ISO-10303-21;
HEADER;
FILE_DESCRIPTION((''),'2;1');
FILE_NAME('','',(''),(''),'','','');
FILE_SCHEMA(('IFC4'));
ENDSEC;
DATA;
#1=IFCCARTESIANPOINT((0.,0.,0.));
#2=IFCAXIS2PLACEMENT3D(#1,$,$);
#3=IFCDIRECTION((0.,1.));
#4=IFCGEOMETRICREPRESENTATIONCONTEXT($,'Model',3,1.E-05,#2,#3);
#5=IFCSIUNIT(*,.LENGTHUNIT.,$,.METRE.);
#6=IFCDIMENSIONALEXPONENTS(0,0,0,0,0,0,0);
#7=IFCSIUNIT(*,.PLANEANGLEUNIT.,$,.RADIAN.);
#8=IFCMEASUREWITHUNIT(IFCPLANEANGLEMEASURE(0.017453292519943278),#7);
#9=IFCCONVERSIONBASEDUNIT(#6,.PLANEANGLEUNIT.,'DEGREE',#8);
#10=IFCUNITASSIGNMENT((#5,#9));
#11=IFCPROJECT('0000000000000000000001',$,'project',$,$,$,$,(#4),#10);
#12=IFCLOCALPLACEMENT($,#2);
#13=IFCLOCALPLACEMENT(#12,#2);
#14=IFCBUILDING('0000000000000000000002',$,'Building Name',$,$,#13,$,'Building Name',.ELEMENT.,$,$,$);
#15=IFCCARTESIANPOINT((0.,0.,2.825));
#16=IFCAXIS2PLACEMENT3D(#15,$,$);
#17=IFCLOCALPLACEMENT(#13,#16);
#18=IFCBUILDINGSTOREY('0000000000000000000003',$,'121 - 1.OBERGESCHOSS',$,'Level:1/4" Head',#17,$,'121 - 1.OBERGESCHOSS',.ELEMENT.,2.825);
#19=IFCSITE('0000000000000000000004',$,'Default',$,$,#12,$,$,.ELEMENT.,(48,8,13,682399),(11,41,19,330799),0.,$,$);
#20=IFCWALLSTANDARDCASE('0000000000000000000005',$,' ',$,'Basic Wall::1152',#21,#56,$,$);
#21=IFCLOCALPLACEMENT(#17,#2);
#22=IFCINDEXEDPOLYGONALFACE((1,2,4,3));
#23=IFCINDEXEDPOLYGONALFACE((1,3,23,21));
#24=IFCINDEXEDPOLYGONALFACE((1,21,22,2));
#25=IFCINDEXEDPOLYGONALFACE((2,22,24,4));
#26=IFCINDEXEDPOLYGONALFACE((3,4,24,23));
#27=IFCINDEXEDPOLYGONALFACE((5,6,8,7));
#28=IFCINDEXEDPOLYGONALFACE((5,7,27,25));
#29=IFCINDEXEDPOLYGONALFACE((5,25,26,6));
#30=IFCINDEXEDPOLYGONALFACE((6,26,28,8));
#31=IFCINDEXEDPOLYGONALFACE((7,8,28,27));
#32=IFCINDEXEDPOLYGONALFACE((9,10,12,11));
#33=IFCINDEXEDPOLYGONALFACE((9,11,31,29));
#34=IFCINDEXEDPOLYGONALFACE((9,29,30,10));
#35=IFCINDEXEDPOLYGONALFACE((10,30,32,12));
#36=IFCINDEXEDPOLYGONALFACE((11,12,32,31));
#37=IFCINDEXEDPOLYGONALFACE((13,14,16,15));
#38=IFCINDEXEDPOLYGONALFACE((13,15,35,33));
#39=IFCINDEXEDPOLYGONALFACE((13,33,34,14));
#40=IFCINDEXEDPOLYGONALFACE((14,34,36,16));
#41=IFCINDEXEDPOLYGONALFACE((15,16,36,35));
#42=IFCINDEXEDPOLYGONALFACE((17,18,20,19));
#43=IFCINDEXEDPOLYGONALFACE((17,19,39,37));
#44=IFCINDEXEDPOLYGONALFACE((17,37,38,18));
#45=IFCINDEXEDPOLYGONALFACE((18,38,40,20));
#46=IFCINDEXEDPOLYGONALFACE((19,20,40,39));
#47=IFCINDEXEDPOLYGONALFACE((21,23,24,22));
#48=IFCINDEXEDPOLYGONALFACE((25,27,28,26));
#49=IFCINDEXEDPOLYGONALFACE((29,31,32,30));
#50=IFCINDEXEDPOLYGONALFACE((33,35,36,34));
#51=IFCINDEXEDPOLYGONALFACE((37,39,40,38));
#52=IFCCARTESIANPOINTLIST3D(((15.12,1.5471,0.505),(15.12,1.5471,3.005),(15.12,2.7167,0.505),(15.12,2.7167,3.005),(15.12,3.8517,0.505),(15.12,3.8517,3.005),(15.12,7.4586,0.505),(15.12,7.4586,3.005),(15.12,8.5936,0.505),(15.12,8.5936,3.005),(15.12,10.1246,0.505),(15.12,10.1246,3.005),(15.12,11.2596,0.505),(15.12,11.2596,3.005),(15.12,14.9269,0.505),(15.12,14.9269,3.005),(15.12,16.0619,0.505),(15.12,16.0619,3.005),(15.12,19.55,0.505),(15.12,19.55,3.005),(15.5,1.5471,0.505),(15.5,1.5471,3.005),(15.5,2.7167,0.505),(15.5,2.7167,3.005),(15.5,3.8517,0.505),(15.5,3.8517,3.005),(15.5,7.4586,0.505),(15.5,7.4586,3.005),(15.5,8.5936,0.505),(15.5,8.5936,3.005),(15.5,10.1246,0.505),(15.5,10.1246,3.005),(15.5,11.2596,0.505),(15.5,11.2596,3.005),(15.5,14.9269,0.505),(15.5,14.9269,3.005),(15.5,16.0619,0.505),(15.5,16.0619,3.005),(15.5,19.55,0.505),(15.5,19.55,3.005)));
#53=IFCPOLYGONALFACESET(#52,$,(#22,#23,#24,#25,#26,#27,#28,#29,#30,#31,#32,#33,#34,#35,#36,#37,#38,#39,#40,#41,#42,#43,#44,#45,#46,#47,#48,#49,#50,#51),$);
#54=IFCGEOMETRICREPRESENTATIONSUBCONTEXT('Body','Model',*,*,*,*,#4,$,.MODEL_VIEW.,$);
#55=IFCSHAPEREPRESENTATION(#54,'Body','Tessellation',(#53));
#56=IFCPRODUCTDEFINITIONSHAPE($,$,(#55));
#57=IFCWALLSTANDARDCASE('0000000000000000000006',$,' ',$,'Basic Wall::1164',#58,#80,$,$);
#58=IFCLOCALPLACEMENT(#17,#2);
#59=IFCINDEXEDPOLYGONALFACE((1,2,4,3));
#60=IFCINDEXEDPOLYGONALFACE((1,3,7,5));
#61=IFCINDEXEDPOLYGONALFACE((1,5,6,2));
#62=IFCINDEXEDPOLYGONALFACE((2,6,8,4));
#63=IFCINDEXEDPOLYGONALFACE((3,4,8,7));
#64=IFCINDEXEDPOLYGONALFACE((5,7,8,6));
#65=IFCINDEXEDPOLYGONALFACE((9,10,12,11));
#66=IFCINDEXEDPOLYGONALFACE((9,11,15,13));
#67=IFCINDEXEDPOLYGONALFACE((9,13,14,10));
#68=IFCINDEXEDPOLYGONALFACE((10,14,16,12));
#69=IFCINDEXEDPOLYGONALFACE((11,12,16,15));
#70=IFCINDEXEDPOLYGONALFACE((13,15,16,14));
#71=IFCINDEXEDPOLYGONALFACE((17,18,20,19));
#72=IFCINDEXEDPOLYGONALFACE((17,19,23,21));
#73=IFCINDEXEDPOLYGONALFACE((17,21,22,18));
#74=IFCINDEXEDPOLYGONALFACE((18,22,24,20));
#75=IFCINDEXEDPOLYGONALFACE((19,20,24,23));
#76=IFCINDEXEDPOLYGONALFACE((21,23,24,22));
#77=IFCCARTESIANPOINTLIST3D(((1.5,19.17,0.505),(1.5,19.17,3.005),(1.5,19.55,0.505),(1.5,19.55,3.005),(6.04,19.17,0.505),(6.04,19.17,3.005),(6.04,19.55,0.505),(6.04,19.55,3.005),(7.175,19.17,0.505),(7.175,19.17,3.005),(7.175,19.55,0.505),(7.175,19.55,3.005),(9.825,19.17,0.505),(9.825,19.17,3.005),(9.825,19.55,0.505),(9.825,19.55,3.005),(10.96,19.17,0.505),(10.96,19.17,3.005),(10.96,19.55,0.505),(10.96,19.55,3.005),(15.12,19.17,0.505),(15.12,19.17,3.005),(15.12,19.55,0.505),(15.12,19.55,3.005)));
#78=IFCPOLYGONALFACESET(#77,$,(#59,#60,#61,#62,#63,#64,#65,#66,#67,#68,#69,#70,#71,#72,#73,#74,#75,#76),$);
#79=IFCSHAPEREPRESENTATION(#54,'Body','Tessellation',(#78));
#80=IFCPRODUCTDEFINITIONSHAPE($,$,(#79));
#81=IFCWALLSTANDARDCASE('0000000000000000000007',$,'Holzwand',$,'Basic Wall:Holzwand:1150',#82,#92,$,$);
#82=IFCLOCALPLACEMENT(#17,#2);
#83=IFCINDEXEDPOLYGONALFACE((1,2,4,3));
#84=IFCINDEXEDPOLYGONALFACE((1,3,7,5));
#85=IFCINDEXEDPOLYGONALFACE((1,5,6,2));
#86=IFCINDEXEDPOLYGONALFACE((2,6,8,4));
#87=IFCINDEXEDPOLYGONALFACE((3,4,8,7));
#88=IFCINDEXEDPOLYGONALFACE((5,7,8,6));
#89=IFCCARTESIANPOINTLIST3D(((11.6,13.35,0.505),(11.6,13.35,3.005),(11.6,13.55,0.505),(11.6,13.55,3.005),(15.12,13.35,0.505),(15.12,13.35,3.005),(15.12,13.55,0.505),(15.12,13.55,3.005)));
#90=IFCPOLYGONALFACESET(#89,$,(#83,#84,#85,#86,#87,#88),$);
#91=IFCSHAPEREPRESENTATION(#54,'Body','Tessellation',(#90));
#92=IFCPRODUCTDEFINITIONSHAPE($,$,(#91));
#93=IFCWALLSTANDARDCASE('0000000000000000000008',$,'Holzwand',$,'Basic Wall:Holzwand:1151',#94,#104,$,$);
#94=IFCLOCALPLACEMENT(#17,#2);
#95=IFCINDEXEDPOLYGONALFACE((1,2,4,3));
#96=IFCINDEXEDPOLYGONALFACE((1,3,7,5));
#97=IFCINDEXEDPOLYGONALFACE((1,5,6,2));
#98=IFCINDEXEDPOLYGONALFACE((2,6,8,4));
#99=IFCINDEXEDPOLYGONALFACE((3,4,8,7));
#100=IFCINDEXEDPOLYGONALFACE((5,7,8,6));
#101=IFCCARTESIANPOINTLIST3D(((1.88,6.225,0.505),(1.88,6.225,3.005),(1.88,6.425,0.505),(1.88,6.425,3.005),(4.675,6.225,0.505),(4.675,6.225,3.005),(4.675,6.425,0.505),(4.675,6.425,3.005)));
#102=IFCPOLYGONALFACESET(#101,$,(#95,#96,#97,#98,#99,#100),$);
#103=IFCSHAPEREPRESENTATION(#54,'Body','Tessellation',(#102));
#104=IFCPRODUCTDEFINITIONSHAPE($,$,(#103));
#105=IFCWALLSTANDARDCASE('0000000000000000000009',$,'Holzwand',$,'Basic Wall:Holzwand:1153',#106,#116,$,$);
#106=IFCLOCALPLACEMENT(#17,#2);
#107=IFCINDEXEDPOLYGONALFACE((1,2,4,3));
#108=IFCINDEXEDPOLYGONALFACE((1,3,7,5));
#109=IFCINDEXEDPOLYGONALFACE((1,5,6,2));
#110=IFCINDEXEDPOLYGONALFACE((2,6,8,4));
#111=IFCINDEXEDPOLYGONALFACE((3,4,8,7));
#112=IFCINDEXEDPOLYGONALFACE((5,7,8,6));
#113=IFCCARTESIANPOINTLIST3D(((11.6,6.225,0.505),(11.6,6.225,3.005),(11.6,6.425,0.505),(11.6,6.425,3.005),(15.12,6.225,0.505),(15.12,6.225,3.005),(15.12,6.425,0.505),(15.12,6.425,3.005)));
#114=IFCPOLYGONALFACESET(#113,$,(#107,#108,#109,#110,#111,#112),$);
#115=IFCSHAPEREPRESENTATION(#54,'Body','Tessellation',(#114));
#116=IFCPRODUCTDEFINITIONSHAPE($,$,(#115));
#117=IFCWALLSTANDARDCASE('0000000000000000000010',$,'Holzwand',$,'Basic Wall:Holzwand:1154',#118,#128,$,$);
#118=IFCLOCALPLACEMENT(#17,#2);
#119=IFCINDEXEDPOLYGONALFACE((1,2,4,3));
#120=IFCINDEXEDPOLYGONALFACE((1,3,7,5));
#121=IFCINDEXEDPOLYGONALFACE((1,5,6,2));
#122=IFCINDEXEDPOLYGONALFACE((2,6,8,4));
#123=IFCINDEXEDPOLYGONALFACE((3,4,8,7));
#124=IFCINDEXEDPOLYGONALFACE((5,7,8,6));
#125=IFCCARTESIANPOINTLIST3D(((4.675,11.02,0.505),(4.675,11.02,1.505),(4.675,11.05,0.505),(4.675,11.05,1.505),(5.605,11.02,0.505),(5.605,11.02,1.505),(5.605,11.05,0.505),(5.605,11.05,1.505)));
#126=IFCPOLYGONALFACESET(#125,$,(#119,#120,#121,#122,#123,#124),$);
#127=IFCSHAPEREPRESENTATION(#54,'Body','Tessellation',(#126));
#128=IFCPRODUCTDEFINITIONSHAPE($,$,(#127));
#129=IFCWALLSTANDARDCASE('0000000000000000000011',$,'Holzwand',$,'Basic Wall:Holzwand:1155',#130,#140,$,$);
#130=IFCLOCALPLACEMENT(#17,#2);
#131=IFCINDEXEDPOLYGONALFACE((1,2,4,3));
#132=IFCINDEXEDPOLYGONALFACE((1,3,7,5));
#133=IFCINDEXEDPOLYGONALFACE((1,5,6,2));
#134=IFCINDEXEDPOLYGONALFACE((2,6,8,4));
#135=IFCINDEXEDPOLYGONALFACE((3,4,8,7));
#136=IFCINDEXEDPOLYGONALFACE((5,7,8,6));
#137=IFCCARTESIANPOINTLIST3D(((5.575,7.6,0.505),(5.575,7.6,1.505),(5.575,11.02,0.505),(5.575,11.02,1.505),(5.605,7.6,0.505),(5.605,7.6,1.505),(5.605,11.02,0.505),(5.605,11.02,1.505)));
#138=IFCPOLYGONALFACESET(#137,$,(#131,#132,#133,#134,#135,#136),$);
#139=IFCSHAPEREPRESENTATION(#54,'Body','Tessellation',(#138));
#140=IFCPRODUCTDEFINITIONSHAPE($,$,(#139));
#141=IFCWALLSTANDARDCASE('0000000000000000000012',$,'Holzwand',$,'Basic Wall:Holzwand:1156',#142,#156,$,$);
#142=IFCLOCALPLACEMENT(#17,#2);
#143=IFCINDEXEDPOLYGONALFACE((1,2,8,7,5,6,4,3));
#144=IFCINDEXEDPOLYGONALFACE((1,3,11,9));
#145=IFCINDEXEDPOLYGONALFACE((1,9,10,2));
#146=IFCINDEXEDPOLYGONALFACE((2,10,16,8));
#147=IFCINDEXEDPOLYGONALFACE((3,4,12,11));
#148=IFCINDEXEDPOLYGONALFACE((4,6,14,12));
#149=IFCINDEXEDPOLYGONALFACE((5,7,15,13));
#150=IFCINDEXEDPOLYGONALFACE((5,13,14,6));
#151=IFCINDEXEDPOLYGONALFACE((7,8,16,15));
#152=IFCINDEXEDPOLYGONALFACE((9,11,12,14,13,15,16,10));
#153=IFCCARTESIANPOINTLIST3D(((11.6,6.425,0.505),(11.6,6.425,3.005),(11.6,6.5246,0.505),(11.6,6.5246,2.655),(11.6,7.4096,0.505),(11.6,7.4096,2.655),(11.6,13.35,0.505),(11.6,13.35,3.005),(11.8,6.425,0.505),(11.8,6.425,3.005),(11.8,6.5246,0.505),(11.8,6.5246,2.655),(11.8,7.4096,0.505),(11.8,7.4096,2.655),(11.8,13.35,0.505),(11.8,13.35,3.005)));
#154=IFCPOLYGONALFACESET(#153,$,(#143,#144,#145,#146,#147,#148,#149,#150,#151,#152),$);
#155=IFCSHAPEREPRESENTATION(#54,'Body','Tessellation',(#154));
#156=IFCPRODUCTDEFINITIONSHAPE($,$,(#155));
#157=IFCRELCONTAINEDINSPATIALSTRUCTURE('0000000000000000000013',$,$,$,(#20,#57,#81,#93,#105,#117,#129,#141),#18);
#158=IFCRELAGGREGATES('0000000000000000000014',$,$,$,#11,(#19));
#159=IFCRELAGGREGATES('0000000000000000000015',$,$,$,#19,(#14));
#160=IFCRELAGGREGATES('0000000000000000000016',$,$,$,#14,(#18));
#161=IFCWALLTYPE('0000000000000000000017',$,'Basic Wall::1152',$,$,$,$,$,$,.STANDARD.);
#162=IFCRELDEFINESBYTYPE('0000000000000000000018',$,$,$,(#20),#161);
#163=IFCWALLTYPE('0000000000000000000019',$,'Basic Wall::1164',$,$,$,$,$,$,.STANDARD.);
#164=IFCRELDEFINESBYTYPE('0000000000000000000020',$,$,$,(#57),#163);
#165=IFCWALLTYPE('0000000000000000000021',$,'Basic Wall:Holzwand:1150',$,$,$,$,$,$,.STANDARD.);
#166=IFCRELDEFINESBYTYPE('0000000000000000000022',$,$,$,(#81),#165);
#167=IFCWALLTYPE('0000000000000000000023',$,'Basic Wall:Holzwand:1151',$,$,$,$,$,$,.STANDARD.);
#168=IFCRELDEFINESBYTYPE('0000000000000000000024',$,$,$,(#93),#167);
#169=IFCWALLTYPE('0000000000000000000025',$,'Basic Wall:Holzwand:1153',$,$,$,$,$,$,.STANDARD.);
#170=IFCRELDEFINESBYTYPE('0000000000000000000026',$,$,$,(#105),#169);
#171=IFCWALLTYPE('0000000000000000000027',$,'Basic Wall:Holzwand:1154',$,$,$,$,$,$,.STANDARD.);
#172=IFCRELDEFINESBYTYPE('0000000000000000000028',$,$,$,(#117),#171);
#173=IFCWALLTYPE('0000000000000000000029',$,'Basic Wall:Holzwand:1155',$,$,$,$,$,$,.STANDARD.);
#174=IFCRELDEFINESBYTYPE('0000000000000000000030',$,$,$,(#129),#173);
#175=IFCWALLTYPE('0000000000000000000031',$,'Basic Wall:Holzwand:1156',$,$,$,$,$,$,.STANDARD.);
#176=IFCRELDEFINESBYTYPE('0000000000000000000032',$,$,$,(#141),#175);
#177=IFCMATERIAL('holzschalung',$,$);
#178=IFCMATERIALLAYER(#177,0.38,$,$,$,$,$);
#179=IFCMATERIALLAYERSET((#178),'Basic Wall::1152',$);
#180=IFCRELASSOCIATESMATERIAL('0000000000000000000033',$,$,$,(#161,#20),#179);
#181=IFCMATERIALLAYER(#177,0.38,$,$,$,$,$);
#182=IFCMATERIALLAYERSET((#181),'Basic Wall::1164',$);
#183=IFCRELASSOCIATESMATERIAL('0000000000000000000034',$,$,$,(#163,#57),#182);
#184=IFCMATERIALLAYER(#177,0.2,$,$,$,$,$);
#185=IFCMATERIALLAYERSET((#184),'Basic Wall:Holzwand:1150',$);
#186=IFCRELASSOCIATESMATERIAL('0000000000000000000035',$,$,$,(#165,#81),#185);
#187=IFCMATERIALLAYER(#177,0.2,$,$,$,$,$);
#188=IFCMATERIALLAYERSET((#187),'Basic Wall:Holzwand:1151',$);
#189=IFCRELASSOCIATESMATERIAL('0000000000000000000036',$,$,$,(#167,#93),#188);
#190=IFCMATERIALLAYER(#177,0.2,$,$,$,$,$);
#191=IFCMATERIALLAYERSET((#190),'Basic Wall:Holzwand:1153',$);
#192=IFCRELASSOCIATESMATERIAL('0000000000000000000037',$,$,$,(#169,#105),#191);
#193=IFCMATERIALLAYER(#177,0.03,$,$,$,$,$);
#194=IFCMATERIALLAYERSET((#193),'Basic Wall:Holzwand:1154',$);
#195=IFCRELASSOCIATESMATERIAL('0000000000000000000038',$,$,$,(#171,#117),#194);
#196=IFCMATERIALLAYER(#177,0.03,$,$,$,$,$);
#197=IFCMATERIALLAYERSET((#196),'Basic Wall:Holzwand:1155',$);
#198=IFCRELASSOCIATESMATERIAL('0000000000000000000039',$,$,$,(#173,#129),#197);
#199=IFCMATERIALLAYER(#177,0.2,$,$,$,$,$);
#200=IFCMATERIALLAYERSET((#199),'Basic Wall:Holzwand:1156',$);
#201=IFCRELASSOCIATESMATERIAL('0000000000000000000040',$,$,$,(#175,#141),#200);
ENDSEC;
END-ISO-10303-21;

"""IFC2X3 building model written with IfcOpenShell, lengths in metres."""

from ifc_helpers import new_model, entity, si_unit, converted_unit, direction, frame, frame_2d, origin, place, context, subcontext, project, spatial, rectangle, extrude, material, layer, layer_set, layer_usage, type_object, element, save


model = new_model("IFC2X3")

# Units and contexts
model_context = context("Model", 3, precision=1e-05, world=origin(), true_north=direction((0.0, 1.0)))
body_context = subcontext(model_context, "Body", "Model", "MODEL_VIEW")
ifc_project = project(units=[si_unit("LENGTHUNIT", "METRE"), converted_unit("PLANEANGLEUNIT", "DEGREE", entity("IfcPlaneAngleMeasure", 0.017453292519943278), si_unit("PLANEANGLEUNIT", "RADIAN"), dimensions=[0, 0, 0, 0, 0, 0, 0])], contexts=[model_context])

# Site, building, storey
site_placement = place(None, origin())
site = spatial("IfcSite", under=ifc_project, at=site_placement, Name="Default", CompositionType="ELEMENT", RefLatitude=(48, 8, 13, 682399), RefLongitude=(11, 41, 19, 330799), RefElevation=0.0)
building_placement = place(site_placement, origin())
building = spatial("IfcBuilding", under=site, at=building_placement, Name="Building Name", LongName="Building Name", CompositionType="ELEMENT")
storey_placement = place(building_placement, frame((0.0, 0.0, 2.825)))
storey = spatial("IfcBuildingStorey", under=building, at=storey_placement, Name="121 - 1.OBERGESCHOSS", ObjectType="Level:1/4\" Head", LongName="121 - 1.OBERGESCHOSS", CompositionType="ELEMENT", Elevation=2.825)

# Walls, openings
ifc_material = material(Name="holzschalung")
ifc_layer_1 = layer(ifc_material, 0.38)
ifc_layer_set_1 = layer_set([ifc_layer_1], Name="Basic Wall::1152")
ifc_layer_usage_1 = layer_usage(ifc_layer_set_1, "AXIS2", "NEGATIVE", 0.19)
wall_type_1 = type_object("IfcWallType", Name="Basic Wall::1152", PredefinedType="STANDARD", material=ifc_layer_set_1)
wall_1_placement = place(storey_placement, frame((15.31, 19.55, 0.505), z_axis=(0.0, 0.0, 1.0), x_axis=(0.0, -1.0, 0.0)))
wall_1 = element("IfcWallStandardCase", 1, at=wall_1_placement, inside=storey, type_object=wall_type_1, material=ifc_layer_usage_1, Name=" ", ObjectType="Basic Wall::1152", context=body_context, shape_type="SweptSolid", body=[
    extrude(rectangle(XDim=18.0029, YDim=0.38, at=frame_2d((9.0014, 0.0), x_axis=(-1.0, 0.0))), origin(), (0.0, 0.0, 1.0), 2.5),
])
opening_1_placement = place(wall_1_placement, origin())
element("IfcOpeningElement", 2, at=opening_1_placement, cuts=wall_1, ObjectType="Opening", context=body_context, shape_type="SweptSolid", body=[
    extrude(rectangle(XDim=2.5, YDim=1.135, at=frame_2d((0.0, 0.0), x_axis=(1.0, 0.0))), frame((4.0556, -0.19, 1.25), z_axis=(0.0, 1.0, 0.0), x_axis=(0.0, 0.0, 1.0)), (0.0, 0.0, 1.0), 0.38),
])
opening_2_placement = place(wall_1_placement, origin())
element("IfcOpeningElement", 3, at=opening_2_placement, cuts=wall_1, ObjectType="Opening", context=body_context, shape_type="SweptSolid", body=[
    extrude(rectangle(XDim=2.5, YDim=1.135, at=frame_2d((0.0, 0.0), x_axis=(1.0, 0.0))), frame((8.8579, -0.19, 1.25), z_axis=(0.0, 1.0, 0.0), x_axis=(0.0, 0.0, 1.0)), (0.0, 0.0, 1.0), 0.38),
])
opening_3_placement = place(wall_1_placement, origin())
element("IfcOpeningElement", 4, at=opening_3_placement, cuts=wall_1, ObjectType="Opening", context=body_context, shape_type="SweptSolid", body=[
    extrude(rectangle(XDim=2.5, YDim=1.135, at=frame_2d((0.0, 0.0), x_axis=(1.0, 0.0))), frame((11.5239, -0.19, 1.25), z_axis=(0.0, 1.0, 0.0), x_axis=(0.0, 0.0, 1.0)), (0.0, 0.0, 1.0), 0.38),
])
opening_4_placement = place(wall_1_placement, origin())
element("IfcOpeningElement", 5, at=opening_4_placement, cuts=wall_1, ObjectType="Opening", context=body_context, shape_type="SweptSolid", body=[
    extrude(rectangle(XDim=2.5, YDim=1.135, at=frame_2d((0.0, 0.0), x_axis=(1.0, 0.0))), frame((16.2658, -0.19, 1.25), z_axis=(0.0, 1.0, 0.0), x_axis=(0.0, 0.0, 1.0)), (0.0, 0.0, 1.0), 0.38),
])
ifc_layer_2 = layer(ifc_material, 0.38)
ifc_layer_set_2 = layer_set([ifc_layer_2], Name="Basic Wall::1164")
ifc_layer_usage_2 = layer_usage(ifc_layer_set_2, "AXIS2", "NEGATIVE", 0.19)
wall_type_2 = type_object("IfcWallType", Name="Basic Wall::1164", PredefinedType="STANDARD", material=ifc_layer_set_2)
wall_2_placement = place(storey_placement, frame((1.5, 19.36, 0.505)))
wall_2 = element("IfcWallStandardCase", 6, at=wall_2_placement, inside=storey, type_object=wall_type_2, material=ifc_layer_usage_2, Name=" ", ObjectType="Basic Wall::1164", context=body_context, shape_type="SweptSolid", body=[
    extrude(rectangle(XDim=13.62, YDim=0.38, at=frame_2d((6.81, 0.0), x_axis=(-1.0, 0.0))), origin(), (0.0, 0.0, 1.0), 2.5),
])
opening_5_placement = place(wall_2_placement, origin())
element("IfcOpeningElement", 7, at=opening_5_placement, cuts=wall_2, ObjectType="Opening", context=body_context, shape_type="SweptSolid", body=[
    extrude(rectangle(XDim=2.5, YDim=1.135, at=frame_2d((0.0, 0.0), x_axis=(1.0, 0.0))), frame((8.8925, -0.19, 1.25), z_axis=(0.0, 1.0, 0.0), x_axis=(0.0, 0.0, 1.0)), (0.0, 0.0, 1.0), 0.38),
])
opening_6_placement = place(wall_2_placement, origin())
element("IfcOpeningElement", 8, at=opening_6_placement, cuts=wall_2, ObjectType="Opening", context=body_context, shape_type="SweptSolid", body=[
    extrude(rectangle(XDim=2.5, YDim=1.135, at=frame_2d((0.0, 0.0), x_axis=(1.0, 0.0))), frame((5.1075, -0.19, 1.25), z_axis=(0.0, 1.0, 0.0), x_axis=(0.0, 0.0, 1.0)), (0.0, 0.0, 1.0), 0.38),
])

# Walls
ifc_layer_3 = layer(ifc_material, 0.2)
ifc_layer_set_3 = layer_set([ifc_layer_3], Name="Basic Wall:Holzwand:1150")
ifc_layer_usage_3 = layer_usage(ifc_layer_set_3, "AXIS2", "NEGATIVE", 0.1)
wall_type_3 = type_object("IfcWallType", Name="Basic Wall:Holzwand:1150", PredefinedType="STANDARD", material=ifc_layer_set_3)
wall_3_placement = place(storey_placement, frame((11.6, 13.45, 0.505)))
element("IfcWallStandardCase", 9, at=wall_3_placement, inside=storey, type_object=wall_type_3, material=ifc_layer_usage_3, Name="Holzwand", ObjectType="Basic Wall:Holzwand:1150", context=body_context, shape_type="SweptSolid", body=[
    extrude(rectangle(XDim=3.52, YDim=0.2, at=frame_2d((1.76, 0.0), x_axis=(-1.0, 0.0))), origin(), (0.0, 0.0, 1.0), 2.5),
])
ifc_layer_4 = layer(ifc_material, 0.2)
ifc_layer_set_4 = layer_set([ifc_layer_4], Name="Basic Wall:Holzwand:1151")
ifc_layer_usage_4 = layer_usage(ifc_layer_set_4, "AXIS2", "NEGATIVE", 0.1)
wall_type_4 = type_object("IfcWallType", Name="Basic Wall:Holzwand:1151", PredefinedType="STANDARD", material=ifc_layer_set_4)
wall_4_placement = place(storey_placement, frame((4.675, 6.325, 0.505), z_axis=(0.0, 0.0, 1.0), x_axis=(-1.0, 0.0, 0.0)))
element("IfcWallStandardCase", 10, at=wall_4_placement, inside=storey, type_object=wall_type_4, material=ifc_layer_usage_4, Name="Holzwand", ObjectType="Basic Wall:Holzwand:1151", context=body_context, shape_type="SweptSolid", body=[
    extrude(rectangle(XDim=2.795, YDim=0.2, at=frame_2d((1.3975, 0.0), x_axis=(-1.0, 0.0))), origin(), (0.0, 0.0, 1.0), 2.5),
])
ifc_layer_5 = layer(ifc_material, 0.2)
ifc_layer_set_5 = layer_set([ifc_layer_5], Name="Basic Wall:Holzwand:1153")
ifc_layer_usage_5 = layer_usage(ifc_layer_set_5, "AXIS2", "NEGATIVE", 0.1)
wall_type_5 = type_object("IfcWallType", Name="Basic Wall:Holzwand:1153", PredefinedType="STANDARD", material=ifc_layer_set_5)
wall_5_placement = place(storey_placement, frame((15.12, 6.325, 0.505), z_axis=(0.0, 0.0, 1.0), x_axis=(-1.0, 0.0, 0.0)))
element("IfcWallStandardCase", 11, at=wall_5_placement, inside=storey, type_object=wall_type_5, material=ifc_layer_usage_5, Name="Holzwand", ObjectType="Basic Wall:Holzwand:1153", context=body_context, shape_type="SweptSolid", body=[
    extrude(rectangle(XDim=3.52, YDim=0.2, at=frame_2d((1.76, 0.0), x_axis=(-1.0, 0.0))), origin(), (0.0, 0.0, 1.0), 2.5),
])
ifc_layer_6 = layer(ifc_material, 0.03)
ifc_layer_set_6 = layer_set([ifc_layer_6], Name="Basic Wall:Holzwand:1154")
ifc_layer_usage_6 = layer_usage(ifc_layer_set_6, "AXIS2", "NEGATIVE", 0.015)
wall_type_6 = type_object("IfcWallType", Name="Basic Wall:Holzwand:1154", PredefinedType="STANDARD", material=ifc_layer_set_6)
wall_6_placement = place(storey_placement, frame((5.605, 11.035, 0.505), z_axis=(0.0, 0.0, 1.0), x_axis=(-1.0, 0.0, 0.0)))
element("IfcWallStandardCase", 12, at=wall_6_placement, inside=storey, type_object=wall_type_6, material=ifc_layer_usage_6, Name="Holzwand", ObjectType="Basic Wall:Holzwand:1154", context=body_context, shape_type="SweptSolid", body=[
    extrude(rectangle(XDim=0.93, YDim=0.03, at=frame_2d((0.465, 0.0), x_axis=(-1.0, 0.0))), origin(), (0.0, 0.0, 1.0), 1.0),
])
ifc_layer_7 = layer(ifc_material, 0.03)
ifc_layer_set_7 = layer_set([ifc_layer_7], Name="Basic Wall:Holzwand:1155")
ifc_layer_usage_7 = layer_usage(ifc_layer_set_7, "AXIS2", "NEGATIVE", 0.015)
wall_type_7 = type_object("IfcWallType", Name="Basic Wall:Holzwand:1155", PredefinedType="STANDARD", material=ifc_layer_set_7)
wall_7_placement = place(storey_placement, frame((5.59, 7.6, 0.505), z_axis=(0.0, 0.0, 1.0), x_axis=(0.0, 1.0, 0.0)))
element("IfcWallStandardCase", 13, at=wall_7_placement, inside=storey, type_object=wall_type_7, material=ifc_layer_usage_7, Name="Holzwand", ObjectType="Basic Wall:Holzwand:1155", context=body_context, shape_type="SweptSolid", body=[
    extrude(rectangle(XDim=3.42, YDim=0.03, at=frame_2d((1.71, 0.0), x_axis=(-1.0, 0.0))), origin(), (0.0, 0.0, 1.0), 1.0),
])

# Wall, opening
ifc_layer_8 = layer(ifc_material, 0.2)
ifc_layer_set_8 = layer_set([ifc_layer_8], Name="Basic Wall:Holzwand:1156")
ifc_layer_usage_8 = layer_usage(ifc_layer_set_8, "AXIS2", "NEGATIVE", 0.1)
wall_type_8 = type_object("IfcWallType", Name="Basic Wall:Holzwand:1156", PredefinedType="STANDARD", material=ifc_layer_set_8)
wall_8_placement = place(storey_placement, frame((11.7, 6.425, 0.505), z_axis=(0.0, 0.0, 1.0), x_axis=(0.0, 1.0, 0.0)))
wall_8 = element("IfcWallStandardCase", 14, at=wall_8_placement, inside=storey, type_object=wall_type_8, material=ifc_layer_usage_8, Name="Holzwand", ObjectType="Basic Wall:Holzwand:1156", context=body_context, shape_type="SweptSolid", body=[
    extrude(rectangle(XDim=6.925, YDim=0.2, at=frame_2d((3.4625, 0.0), x_axis=(1.0, 0.0))), origin(), (0.0, 0.0, 1.0), 2.5),
])
opening_7_placement = place(wall_8_placement, frame((-6.425, 11.7, -0.505), z_axis=(0.0, 0.0, 1.0), x_axis=(0.0, -1.0, 0.0)))
element("IfcOpeningElement", 15, at=opening_7_placement, cuts=wall_8, ObjectType="Opening", context=body_context, shape_type="SweptSolid", body=[
    extrude(rectangle(XDim=2.3, YDim=0.885, at=frame_2d((0.0, 0.0), x_axis=(0.0, 1.0))), frame((11.802, 6.9671, 1.505), z_axis=(-1.0, 0.0, 0.0), x_axis=(0.0, -1.0, 0.0)), (0.0, 0.0, 1.0), 0.204),
])

save(model, "model.ifc")
